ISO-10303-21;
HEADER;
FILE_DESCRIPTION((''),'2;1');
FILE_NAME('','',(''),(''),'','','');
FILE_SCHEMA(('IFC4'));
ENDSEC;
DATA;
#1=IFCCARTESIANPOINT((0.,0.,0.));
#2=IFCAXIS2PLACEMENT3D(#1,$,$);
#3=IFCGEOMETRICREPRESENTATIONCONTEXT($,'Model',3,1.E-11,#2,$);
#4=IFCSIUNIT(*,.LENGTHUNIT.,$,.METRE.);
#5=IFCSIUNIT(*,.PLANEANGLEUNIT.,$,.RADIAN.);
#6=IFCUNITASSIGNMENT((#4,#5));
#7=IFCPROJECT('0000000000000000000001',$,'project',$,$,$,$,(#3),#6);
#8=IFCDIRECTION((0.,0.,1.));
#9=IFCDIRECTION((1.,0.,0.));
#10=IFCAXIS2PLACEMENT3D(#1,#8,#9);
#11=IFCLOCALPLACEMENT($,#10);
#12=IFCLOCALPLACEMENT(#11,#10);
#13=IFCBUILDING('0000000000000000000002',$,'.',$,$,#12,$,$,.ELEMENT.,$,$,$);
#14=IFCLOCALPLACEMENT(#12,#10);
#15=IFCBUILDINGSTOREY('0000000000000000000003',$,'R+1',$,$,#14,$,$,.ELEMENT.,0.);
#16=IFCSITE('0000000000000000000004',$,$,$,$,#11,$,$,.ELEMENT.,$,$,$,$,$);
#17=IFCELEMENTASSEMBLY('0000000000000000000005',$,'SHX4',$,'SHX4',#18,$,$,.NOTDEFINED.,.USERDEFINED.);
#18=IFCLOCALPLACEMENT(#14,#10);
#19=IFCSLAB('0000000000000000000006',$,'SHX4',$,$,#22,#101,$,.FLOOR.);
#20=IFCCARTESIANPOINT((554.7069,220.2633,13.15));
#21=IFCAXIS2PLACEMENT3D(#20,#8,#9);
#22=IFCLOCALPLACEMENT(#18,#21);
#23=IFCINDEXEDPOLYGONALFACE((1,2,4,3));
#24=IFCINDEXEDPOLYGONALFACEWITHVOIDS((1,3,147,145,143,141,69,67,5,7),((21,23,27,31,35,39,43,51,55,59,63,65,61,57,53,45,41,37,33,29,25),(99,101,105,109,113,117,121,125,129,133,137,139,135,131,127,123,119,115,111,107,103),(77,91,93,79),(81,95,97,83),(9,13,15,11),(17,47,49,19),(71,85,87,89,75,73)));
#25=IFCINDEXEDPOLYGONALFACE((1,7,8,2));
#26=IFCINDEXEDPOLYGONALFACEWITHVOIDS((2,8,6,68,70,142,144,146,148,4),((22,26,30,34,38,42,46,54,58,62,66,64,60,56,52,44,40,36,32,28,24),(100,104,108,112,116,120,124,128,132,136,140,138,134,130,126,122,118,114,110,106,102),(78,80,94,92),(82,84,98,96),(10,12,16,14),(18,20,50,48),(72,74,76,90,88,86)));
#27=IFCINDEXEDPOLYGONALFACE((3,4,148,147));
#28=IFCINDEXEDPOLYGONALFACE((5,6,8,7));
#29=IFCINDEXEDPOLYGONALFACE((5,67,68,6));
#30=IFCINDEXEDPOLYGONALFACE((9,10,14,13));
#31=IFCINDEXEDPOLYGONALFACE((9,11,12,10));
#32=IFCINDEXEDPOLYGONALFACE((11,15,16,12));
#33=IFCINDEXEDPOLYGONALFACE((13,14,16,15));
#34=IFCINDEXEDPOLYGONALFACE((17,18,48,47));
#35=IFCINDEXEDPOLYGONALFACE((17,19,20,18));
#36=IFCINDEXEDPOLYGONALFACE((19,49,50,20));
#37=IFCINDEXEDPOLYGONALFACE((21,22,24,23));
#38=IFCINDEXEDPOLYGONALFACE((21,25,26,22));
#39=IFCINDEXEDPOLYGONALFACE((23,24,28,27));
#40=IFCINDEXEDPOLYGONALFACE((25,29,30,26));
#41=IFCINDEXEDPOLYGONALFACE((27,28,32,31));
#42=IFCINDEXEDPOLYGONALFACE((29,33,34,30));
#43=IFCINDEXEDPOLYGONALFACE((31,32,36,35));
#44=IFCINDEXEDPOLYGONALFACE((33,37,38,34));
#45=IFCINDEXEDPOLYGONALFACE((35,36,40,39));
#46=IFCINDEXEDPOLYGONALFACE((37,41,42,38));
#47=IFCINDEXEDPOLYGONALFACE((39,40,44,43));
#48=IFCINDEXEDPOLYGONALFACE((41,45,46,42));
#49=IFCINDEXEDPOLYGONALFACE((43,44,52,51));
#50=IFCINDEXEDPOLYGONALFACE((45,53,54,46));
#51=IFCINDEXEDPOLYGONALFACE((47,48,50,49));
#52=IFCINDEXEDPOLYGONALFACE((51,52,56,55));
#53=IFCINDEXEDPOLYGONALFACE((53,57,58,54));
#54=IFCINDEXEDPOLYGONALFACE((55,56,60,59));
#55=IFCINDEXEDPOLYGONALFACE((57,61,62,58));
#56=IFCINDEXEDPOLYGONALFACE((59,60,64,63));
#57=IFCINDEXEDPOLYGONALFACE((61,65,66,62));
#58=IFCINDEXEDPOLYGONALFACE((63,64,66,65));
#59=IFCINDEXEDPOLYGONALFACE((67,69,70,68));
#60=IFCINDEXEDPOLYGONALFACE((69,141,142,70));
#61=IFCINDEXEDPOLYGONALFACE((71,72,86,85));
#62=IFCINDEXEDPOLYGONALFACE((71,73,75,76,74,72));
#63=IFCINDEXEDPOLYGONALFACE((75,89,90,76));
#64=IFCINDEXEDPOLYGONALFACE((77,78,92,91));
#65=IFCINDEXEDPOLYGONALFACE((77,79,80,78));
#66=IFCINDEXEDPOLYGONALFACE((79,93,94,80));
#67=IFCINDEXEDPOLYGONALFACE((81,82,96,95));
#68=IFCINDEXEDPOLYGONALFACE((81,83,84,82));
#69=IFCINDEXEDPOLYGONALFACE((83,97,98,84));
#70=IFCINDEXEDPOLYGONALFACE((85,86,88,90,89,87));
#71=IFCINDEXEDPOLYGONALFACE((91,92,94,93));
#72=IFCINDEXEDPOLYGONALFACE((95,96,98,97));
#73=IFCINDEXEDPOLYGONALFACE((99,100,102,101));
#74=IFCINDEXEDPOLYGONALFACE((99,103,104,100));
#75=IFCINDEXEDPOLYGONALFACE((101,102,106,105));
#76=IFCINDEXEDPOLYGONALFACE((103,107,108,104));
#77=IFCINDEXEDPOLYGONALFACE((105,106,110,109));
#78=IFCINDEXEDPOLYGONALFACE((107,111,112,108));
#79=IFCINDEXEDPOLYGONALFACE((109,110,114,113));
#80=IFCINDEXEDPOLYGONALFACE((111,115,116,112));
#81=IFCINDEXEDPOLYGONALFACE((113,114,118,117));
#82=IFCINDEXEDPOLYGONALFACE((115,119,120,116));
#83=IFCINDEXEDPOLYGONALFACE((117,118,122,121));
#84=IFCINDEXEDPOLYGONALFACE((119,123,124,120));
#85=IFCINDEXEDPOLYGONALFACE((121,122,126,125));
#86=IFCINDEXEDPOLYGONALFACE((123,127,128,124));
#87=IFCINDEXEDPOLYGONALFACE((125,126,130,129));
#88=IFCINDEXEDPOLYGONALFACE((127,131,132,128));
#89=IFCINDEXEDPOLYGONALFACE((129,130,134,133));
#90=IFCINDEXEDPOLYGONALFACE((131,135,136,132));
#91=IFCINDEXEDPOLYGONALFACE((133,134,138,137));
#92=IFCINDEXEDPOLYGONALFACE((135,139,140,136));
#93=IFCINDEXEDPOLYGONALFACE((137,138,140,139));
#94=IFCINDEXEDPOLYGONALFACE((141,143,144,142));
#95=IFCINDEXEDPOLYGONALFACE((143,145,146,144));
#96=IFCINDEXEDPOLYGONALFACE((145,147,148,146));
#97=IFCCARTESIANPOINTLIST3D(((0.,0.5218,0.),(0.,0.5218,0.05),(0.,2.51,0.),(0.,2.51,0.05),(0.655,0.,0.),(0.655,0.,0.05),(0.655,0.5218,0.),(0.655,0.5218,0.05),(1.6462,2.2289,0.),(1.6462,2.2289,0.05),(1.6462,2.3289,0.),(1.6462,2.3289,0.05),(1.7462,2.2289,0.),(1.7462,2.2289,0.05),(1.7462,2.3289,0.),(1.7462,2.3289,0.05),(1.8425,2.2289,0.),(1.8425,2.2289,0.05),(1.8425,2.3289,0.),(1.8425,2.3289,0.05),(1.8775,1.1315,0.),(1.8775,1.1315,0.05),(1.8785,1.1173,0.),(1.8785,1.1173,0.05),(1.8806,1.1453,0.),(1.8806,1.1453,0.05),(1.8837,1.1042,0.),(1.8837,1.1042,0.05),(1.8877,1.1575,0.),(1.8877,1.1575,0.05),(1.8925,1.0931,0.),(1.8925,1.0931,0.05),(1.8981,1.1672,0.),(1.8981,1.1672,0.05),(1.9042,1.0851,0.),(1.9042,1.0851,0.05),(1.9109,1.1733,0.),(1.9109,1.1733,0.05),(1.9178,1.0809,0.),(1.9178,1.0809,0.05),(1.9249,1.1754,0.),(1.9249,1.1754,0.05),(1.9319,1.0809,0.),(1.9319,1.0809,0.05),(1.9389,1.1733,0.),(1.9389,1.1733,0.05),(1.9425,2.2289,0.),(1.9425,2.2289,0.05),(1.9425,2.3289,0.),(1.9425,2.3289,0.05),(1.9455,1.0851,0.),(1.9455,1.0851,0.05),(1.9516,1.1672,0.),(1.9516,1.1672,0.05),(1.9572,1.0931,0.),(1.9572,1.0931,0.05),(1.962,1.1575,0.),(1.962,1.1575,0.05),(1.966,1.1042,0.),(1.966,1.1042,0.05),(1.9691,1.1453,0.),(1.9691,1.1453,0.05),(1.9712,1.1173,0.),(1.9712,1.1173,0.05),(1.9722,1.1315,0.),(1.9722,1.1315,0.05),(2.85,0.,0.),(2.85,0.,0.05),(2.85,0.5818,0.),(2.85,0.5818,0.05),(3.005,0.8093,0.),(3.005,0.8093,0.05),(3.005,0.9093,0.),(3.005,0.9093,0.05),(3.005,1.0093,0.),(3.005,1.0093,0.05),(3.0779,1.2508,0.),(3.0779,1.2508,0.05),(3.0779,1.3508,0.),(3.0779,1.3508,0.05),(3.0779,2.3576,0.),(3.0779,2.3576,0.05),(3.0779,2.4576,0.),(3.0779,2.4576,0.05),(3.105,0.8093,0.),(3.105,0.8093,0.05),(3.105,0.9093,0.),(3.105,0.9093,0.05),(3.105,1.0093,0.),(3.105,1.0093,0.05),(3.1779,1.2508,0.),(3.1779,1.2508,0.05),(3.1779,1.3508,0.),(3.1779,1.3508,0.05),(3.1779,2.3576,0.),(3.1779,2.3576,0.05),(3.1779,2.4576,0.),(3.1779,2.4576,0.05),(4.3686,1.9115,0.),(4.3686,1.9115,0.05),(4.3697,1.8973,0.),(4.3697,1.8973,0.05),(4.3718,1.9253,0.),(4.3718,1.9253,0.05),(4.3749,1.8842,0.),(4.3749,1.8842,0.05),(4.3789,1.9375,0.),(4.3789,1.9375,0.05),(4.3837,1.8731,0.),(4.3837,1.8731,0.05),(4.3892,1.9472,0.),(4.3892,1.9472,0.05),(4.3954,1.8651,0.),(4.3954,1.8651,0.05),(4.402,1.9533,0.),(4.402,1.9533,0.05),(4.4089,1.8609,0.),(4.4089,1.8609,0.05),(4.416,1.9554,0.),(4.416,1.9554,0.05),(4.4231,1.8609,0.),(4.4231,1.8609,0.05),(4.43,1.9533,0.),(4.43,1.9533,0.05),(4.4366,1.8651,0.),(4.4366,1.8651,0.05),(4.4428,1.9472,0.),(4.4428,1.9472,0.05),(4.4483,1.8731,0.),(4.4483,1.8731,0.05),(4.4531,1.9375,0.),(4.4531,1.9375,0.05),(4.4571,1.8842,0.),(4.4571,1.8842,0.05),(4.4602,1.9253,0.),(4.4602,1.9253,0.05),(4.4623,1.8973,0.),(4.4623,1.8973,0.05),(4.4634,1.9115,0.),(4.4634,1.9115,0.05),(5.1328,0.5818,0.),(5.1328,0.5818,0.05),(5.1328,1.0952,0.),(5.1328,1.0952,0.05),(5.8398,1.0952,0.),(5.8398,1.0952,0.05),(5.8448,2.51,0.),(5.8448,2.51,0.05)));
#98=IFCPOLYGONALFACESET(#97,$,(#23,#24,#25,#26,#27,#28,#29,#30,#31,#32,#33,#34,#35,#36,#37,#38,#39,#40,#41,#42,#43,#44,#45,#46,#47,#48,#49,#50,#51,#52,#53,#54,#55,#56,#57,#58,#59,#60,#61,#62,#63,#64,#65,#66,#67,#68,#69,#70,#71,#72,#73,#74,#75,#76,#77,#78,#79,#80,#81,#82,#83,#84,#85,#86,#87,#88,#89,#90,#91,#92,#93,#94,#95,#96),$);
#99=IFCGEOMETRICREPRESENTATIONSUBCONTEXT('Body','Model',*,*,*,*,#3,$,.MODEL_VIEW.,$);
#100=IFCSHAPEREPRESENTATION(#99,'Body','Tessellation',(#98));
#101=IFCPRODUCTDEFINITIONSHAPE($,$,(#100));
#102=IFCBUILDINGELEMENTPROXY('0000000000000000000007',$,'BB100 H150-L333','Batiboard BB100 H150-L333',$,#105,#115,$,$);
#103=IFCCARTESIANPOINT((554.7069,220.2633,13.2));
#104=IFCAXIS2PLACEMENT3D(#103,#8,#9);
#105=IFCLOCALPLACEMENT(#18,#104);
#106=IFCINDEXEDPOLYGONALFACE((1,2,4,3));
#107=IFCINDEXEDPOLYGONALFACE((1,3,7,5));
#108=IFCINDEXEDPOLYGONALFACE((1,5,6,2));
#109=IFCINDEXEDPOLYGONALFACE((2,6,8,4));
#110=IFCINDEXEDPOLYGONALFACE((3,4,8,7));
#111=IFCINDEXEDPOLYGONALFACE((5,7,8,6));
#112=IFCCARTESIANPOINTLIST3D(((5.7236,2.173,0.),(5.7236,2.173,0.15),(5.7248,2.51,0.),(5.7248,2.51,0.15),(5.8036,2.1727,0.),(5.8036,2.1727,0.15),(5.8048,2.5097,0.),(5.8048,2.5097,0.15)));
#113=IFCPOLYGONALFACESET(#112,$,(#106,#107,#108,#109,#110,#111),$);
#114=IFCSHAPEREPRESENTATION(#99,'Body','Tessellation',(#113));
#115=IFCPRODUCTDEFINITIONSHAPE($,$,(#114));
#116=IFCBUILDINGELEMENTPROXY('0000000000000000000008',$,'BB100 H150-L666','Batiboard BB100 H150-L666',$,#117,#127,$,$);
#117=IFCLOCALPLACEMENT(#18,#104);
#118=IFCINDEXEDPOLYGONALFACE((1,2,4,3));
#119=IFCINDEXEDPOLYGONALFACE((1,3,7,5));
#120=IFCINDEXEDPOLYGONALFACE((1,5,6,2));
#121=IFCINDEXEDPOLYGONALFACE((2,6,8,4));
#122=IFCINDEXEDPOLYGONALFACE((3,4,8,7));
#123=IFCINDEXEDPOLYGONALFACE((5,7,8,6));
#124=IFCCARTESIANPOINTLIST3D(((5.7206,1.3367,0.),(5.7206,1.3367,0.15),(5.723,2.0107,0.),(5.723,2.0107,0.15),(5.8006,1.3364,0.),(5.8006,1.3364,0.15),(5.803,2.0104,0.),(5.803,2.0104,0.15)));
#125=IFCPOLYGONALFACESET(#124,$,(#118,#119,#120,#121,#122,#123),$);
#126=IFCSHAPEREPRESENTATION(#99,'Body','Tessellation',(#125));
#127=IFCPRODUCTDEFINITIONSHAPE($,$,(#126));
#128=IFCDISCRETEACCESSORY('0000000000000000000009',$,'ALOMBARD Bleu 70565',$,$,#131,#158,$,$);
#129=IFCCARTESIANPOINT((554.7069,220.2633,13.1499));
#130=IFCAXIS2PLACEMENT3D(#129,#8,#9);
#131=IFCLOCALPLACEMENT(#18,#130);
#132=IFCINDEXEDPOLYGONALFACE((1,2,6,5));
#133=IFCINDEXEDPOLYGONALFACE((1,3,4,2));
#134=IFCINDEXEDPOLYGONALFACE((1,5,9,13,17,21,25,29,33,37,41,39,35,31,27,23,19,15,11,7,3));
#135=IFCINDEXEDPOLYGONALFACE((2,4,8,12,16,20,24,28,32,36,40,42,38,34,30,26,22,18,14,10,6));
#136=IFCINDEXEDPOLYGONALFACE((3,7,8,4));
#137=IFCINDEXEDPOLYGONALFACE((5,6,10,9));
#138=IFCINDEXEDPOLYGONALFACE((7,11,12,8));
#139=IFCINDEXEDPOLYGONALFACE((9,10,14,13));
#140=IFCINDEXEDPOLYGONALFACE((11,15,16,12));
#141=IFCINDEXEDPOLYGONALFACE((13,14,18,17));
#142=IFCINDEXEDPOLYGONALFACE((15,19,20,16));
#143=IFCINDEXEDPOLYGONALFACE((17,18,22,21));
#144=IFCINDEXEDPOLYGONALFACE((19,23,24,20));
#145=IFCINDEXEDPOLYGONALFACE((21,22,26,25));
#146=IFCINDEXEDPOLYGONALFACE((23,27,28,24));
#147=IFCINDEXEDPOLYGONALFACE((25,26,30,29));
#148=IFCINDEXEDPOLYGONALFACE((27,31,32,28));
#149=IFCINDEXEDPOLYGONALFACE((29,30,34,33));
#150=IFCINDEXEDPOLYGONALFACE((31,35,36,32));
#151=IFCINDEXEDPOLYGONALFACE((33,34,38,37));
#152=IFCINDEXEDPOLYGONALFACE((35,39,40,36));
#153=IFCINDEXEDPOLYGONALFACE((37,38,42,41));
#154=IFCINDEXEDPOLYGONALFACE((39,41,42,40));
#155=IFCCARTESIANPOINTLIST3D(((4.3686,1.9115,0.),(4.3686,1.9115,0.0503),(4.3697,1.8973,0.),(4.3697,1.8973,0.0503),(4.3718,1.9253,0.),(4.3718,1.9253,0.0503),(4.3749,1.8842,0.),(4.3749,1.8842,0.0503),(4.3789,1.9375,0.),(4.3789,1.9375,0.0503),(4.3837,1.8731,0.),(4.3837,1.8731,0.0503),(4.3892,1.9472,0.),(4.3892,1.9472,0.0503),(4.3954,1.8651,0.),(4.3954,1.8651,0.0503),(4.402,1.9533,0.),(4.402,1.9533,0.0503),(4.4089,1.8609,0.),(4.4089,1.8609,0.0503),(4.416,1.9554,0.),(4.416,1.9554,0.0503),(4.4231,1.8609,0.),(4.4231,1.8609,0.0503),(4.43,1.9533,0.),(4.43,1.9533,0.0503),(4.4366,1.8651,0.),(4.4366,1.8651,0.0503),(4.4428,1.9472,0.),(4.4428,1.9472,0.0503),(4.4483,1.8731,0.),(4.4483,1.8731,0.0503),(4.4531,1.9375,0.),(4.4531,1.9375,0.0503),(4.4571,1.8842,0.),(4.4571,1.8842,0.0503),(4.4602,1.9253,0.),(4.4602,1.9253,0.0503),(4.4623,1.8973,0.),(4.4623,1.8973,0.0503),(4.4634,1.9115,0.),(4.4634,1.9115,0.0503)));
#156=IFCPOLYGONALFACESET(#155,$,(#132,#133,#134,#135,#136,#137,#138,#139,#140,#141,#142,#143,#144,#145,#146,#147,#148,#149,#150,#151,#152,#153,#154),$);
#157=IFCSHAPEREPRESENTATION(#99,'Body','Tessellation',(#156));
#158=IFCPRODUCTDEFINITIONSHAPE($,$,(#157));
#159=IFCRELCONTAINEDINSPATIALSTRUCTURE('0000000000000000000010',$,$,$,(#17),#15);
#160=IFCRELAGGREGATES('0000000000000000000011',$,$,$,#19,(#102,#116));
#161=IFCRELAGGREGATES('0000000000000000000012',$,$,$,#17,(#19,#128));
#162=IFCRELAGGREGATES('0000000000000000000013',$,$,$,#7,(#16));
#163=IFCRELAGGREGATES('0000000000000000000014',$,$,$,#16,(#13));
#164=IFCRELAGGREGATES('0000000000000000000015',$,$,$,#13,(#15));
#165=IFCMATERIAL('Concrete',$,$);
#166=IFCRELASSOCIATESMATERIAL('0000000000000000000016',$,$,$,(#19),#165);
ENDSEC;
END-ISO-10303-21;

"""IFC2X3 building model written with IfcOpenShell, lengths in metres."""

from ifc_helpers import new_model, si_unit, frame, frame_2d, origin, origin_with_axes, origin_2d_with_axis, place, context, subcontext, project, spatial, polyline, circle, outline, extrude, material, element, aggregate, save


model = new_model("IFC2X3")

# Units and contexts
model_context = context("Model", 3, precision=1e-11, world=origin())
body_context = subcontext(model_context, "Body", "Model", "MODEL_VIEW")
ifc_project = project(units=[si_unit("LENGTHUNIT", "METRE"), si_unit("PLANEANGLEUNIT", "RADIAN")], contexts=[model_context])

# Site, building, storey
site_placement = place(None, origin_with_axes())
site = spatial("IfcSite", under=ifc_project, at=site_placement, CompositionType="ELEMENT")
building_placement = place(site_placement, origin_with_axes())
building = spatial("IfcBuilding", under=site, at=building_placement, Name=".", CompositionType="ELEMENT")
storey_placement = place(building_placement, origin_with_axes())
storey = spatial("IfcBuildingStorey", under=building, at=storey_placement, Name="R+1", CompositionType="ELEMENT", Elevation=0.0)

# Element assembly, slab, openings, building element proxies, discrete accessory
assembly_1_placement = place(storey_placement, origin_with_axes())
assembly_1 = element("IfcElementAssembly", 1, at=assembly_1_placement, inside=storey, Name="SHX4", ObjectType="SHX4", AssemblyPlace="NOTDEFINED", PredefinedType="USERDEFINED")
ifc_material = material(Name="Concrete")
slab_placement = place(assembly_1_placement, frame((554.7069, 220.2633, 13.15), z_axis=(0.0, 0.0, 1.0), x_axis=(1.0, 0.0, 0.0)))
slab = element("IfcSlab", 2, at=slab_placement, material=ifc_material, Name="SHX4", PredefinedType="FLOOR", context=body_context, shape_type="SweptSolid", body=[
    extrude(outline(polyline([(0.0, -0.655), (0.0, -2.85), (0.5818, -2.85), (0.5818, -5.1328), (1.0952, -5.1328), (1.0952, -5.8398), (2.51, -5.8448), (2.51, 0.0), (0.5218, 0.0), (0.5218, -0.655), (0.0, -0.655)])), frame((0.0, 0.0, 0.0), z_axis=(0.0, 0.0, 1.0), x_axis=(0.0, 1.0, 0.0)), (0.0, 0.0, 1.0), 0.05),
])
opening_1_placement = place(slab_placement, frame((4.416, 1.9079, 0.0), z_axis=(0.0, 0.0, 1.0), x_axis=(1.0, 0.0, 0.0)))
element("IfcOpeningElement", 3, at=opening_1_placement, cuts=slab, ObjectType="Opening", context=body_context, shape_type="SweptSolid", body=[
    extrude(circle(Radius=0.0475, at=origin_2d_with_axis()), frame((0.0, 0.0, 0.0), z_axis=(0.0, 0.0, 1.0), x_axis=(0.0, 1.0, 0.0)), (0.0, 0.0, 1.0), 0.05),
])
opening_2_placement = place(slab_placement, frame((1.9249, 1.1279, 0.0), z_axis=(0.0, 0.0, 1.0), x_axis=(1.0, 0.0, 0.0)))
element("IfcOpeningElement", 4, at=opening_2_placement, cuts=slab, ObjectType="Opening", context=body_context, shape_type="SweptSolid", body=[
    extrude(circle(Radius=0.0475, at=origin_2d_with_axis()), frame((0.0, 0.0, 0.0), z_axis=(0.0, 0.0, 1.0), x_axis=(0.0, 1.0, 0.0)), (0.0, 0.0, 1.0), 0.05),
])
opening_3_placement = place(slab_placement, origin_with_axes())
element("IfcOpeningElement", 5, at=opening_3_placement, cuts=slab, ObjectType="Opening", context=body_context, shape_type="SweptSolid", body=[
    extrude(outline(polyline([(0.8093, -3.005), (0.8093, -3.105), (0.9093, -3.105), (0.9093, -3.005), (0.8093, -3.005)])), frame((0.0, 0.0, 0.0), z_axis=(0.0, 0.0, 1.0), x_axis=(0.0, 1.0, 0.0)), (0.0, 0.0, 1.0), 0.05),
])
opening_4_placement = place(slab_placement, origin_with_axes())
element("IfcOpeningElement", 6, at=opening_4_placement, cuts=slab, ObjectType="Opening", context=body_context, shape_type="SweptSolid", body=[
    extrude(outline(polyline([(0.9093, -3.005), (0.9093, -3.105), (1.0093, -3.105), (1.0093, -3.005), (0.9093, -3.005)])), frame((0.0, 0.0, 0.0), z_axis=(0.0, 0.0, 1.0), x_axis=(0.0, 1.0, 0.0)), (0.0, 0.0, 1.0), 0.05),
])
opening_5_placement = place(slab_placement, origin_with_axes())
element("IfcOpeningElement", 7, at=opening_5_placement, cuts=slab, ObjectType="Opening", context=body_context, shape_type="SweptSolid", body=[
    extrude(outline(polyline([(2.2289, -1.6462), (2.2289, -1.7462), (2.3289, -1.7462), (2.3289, -1.6462), (2.2289, -1.6462)])), frame((0.0, 0.0, 0.0), z_axis=(0.0, 0.0, 1.0), x_axis=(0.0, 1.0, 0.0)), (0.0, 0.0, 1.0), 0.05),
])
opening_6_placement = place(slab_placement, origin_with_axes())
element("IfcOpeningElement", 8, at=opening_6_placement, cuts=slab, ObjectType="Opening", context=body_context, shape_type="SweptSolid", body=[
    extrude(outline(polyline([(2.2289, -1.8425), (2.2289, -1.9425), (2.3289, -1.9425), (2.3289, -1.8425), (2.2289, -1.8425)])), frame((0.0, 0.0, 0.0), z_axis=(0.0, 0.0, 1.0), x_axis=(0.0, 1.0, 0.0)), (0.0, 0.0, 1.0), 0.05),
])
opening_7_placement = place(slab_placement, origin_with_axes())
element("IfcOpeningElement", 9, at=opening_7_placement, cuts=slab, ObjectType="Opening", context=body_context, shape_type="SweptSolid", body=[
    extrude(outline(polyline([(2.3576, -3.0779), (2.3576, -3.1779), (2.4576, -3.1779), (2.4576, -3.0779), (2.3576, -3.0779)])), frame((0.0, 0.0, 0.0), z_axis=(0.0, 0.0, 1.0), x_axis=(0.0, 1.0, 0.0)), (0.0, 0.0, 1.0), 0.05),
])
opening_8_placement = place(slab_placement, origin_with_axes())
element("IfcOpeningElement", 10, at=opening_8_placement, cuts=slab, ObjectType="Opening", context=body_context, shape_type="SweptSolid", body=[
    extrude(outline(polyline([(1.2508, -3.0779), (1.2508, -3.1779), (1.3508, -3.1779), (1.3508, -3.0779), (1.2508, -3.0779)])), frame((0.0, 0.0, 0.0), z_axis=(0.0, 0.0, 1.0), x_axis=(0.0, 1.0, 0.0)), (0.0, 0.0, 1.0), 0.05),
])
proxy_1_placement = place(assembly_1_placement, frame((554.7069, 220.2633, 13.2), z_axis=(0.0, 0.0, 1.0), x_axis=(1.0, 0.0, 0.0)))
proxy_1 = element("IfcBuildingElementProxy", 11, at=proxy_1_placement, Name="BB100 H150-L333", Description="Batiboard BB100 H150-L333", context=body_context, shape_type="SweptSolid", body=[
    extrude(outline(polyline([(2.51, -5.7248), (2.173, -5.7236), (2.1727, -5.8036), (2.5097, -5.8048), (2.51, -5.7248)])), frame((0.0, 0.0, 0.0), z_axis=(0.0, 0.0, 1.0), x_axis=(0.0, 1.0, 0.0)), (0.0, 0.0, 1.0), 0.15),
])
proxy_2_placement = place(assembly_1_placement, frame((554.7069, 220.2633, 13.2), z_axis=(0.0, 0.0, 1.0), x_axis=(1.0, 0.0, 0.0)))
proxy_2 = element("IfcBuildingElementProxy", 12, at=proxy_2_placement, Name="BB100 H150-L666", Description="Batiboard BB100 H150-L666", context=body_context, shape_type="SweptSolid", body=[
    extrude(outline(polyline([(2.0107, -5.723), (1.3367, -5.7206), (1.3364, -5.8006), (2.0104, -5.803), (2.0107, -5.723)])), frame((0.0, 0.0, 0.0), z_axis=(0.0, 0.0, 1.0), x_axis=(0.0, 1.0, 0.0)), (0.0, 0.0, 1.0), 0.15),
])
aggregate(slab, [proxy_1, proxy_2])
discrete_accessory_1_placement = place(assembly_1_placement, frame((554.7069, 220.2633, 13.1499), z_axis=(0.0, 0.0, 1.0), x_axis=(1.0, 0.0, 0.0)))
discrete_accessory_1 = element("IfcDiscreteAccessory", 13, at=discrete_accessory_1_placement, Name="ALOMBARD Bleu 70565", context=body_context, shape_type="SweptSolid", body=[
    extrude(circle(Radius=0.0475, at=frame_2d((1.9079, -4.416), x_axis=(1.0, 0.0))), frame((0.0, 0.0, 0.0), z_axis=(0.0, 0.0, 1.0), x_axis=(0.0, 1.0, 0.0)), (0.0, 0.0, 1.0), 0.0503),
])
aggregate(assembly_1, [slab, discrete_accessory_1])

save(model, "model.ifc")
